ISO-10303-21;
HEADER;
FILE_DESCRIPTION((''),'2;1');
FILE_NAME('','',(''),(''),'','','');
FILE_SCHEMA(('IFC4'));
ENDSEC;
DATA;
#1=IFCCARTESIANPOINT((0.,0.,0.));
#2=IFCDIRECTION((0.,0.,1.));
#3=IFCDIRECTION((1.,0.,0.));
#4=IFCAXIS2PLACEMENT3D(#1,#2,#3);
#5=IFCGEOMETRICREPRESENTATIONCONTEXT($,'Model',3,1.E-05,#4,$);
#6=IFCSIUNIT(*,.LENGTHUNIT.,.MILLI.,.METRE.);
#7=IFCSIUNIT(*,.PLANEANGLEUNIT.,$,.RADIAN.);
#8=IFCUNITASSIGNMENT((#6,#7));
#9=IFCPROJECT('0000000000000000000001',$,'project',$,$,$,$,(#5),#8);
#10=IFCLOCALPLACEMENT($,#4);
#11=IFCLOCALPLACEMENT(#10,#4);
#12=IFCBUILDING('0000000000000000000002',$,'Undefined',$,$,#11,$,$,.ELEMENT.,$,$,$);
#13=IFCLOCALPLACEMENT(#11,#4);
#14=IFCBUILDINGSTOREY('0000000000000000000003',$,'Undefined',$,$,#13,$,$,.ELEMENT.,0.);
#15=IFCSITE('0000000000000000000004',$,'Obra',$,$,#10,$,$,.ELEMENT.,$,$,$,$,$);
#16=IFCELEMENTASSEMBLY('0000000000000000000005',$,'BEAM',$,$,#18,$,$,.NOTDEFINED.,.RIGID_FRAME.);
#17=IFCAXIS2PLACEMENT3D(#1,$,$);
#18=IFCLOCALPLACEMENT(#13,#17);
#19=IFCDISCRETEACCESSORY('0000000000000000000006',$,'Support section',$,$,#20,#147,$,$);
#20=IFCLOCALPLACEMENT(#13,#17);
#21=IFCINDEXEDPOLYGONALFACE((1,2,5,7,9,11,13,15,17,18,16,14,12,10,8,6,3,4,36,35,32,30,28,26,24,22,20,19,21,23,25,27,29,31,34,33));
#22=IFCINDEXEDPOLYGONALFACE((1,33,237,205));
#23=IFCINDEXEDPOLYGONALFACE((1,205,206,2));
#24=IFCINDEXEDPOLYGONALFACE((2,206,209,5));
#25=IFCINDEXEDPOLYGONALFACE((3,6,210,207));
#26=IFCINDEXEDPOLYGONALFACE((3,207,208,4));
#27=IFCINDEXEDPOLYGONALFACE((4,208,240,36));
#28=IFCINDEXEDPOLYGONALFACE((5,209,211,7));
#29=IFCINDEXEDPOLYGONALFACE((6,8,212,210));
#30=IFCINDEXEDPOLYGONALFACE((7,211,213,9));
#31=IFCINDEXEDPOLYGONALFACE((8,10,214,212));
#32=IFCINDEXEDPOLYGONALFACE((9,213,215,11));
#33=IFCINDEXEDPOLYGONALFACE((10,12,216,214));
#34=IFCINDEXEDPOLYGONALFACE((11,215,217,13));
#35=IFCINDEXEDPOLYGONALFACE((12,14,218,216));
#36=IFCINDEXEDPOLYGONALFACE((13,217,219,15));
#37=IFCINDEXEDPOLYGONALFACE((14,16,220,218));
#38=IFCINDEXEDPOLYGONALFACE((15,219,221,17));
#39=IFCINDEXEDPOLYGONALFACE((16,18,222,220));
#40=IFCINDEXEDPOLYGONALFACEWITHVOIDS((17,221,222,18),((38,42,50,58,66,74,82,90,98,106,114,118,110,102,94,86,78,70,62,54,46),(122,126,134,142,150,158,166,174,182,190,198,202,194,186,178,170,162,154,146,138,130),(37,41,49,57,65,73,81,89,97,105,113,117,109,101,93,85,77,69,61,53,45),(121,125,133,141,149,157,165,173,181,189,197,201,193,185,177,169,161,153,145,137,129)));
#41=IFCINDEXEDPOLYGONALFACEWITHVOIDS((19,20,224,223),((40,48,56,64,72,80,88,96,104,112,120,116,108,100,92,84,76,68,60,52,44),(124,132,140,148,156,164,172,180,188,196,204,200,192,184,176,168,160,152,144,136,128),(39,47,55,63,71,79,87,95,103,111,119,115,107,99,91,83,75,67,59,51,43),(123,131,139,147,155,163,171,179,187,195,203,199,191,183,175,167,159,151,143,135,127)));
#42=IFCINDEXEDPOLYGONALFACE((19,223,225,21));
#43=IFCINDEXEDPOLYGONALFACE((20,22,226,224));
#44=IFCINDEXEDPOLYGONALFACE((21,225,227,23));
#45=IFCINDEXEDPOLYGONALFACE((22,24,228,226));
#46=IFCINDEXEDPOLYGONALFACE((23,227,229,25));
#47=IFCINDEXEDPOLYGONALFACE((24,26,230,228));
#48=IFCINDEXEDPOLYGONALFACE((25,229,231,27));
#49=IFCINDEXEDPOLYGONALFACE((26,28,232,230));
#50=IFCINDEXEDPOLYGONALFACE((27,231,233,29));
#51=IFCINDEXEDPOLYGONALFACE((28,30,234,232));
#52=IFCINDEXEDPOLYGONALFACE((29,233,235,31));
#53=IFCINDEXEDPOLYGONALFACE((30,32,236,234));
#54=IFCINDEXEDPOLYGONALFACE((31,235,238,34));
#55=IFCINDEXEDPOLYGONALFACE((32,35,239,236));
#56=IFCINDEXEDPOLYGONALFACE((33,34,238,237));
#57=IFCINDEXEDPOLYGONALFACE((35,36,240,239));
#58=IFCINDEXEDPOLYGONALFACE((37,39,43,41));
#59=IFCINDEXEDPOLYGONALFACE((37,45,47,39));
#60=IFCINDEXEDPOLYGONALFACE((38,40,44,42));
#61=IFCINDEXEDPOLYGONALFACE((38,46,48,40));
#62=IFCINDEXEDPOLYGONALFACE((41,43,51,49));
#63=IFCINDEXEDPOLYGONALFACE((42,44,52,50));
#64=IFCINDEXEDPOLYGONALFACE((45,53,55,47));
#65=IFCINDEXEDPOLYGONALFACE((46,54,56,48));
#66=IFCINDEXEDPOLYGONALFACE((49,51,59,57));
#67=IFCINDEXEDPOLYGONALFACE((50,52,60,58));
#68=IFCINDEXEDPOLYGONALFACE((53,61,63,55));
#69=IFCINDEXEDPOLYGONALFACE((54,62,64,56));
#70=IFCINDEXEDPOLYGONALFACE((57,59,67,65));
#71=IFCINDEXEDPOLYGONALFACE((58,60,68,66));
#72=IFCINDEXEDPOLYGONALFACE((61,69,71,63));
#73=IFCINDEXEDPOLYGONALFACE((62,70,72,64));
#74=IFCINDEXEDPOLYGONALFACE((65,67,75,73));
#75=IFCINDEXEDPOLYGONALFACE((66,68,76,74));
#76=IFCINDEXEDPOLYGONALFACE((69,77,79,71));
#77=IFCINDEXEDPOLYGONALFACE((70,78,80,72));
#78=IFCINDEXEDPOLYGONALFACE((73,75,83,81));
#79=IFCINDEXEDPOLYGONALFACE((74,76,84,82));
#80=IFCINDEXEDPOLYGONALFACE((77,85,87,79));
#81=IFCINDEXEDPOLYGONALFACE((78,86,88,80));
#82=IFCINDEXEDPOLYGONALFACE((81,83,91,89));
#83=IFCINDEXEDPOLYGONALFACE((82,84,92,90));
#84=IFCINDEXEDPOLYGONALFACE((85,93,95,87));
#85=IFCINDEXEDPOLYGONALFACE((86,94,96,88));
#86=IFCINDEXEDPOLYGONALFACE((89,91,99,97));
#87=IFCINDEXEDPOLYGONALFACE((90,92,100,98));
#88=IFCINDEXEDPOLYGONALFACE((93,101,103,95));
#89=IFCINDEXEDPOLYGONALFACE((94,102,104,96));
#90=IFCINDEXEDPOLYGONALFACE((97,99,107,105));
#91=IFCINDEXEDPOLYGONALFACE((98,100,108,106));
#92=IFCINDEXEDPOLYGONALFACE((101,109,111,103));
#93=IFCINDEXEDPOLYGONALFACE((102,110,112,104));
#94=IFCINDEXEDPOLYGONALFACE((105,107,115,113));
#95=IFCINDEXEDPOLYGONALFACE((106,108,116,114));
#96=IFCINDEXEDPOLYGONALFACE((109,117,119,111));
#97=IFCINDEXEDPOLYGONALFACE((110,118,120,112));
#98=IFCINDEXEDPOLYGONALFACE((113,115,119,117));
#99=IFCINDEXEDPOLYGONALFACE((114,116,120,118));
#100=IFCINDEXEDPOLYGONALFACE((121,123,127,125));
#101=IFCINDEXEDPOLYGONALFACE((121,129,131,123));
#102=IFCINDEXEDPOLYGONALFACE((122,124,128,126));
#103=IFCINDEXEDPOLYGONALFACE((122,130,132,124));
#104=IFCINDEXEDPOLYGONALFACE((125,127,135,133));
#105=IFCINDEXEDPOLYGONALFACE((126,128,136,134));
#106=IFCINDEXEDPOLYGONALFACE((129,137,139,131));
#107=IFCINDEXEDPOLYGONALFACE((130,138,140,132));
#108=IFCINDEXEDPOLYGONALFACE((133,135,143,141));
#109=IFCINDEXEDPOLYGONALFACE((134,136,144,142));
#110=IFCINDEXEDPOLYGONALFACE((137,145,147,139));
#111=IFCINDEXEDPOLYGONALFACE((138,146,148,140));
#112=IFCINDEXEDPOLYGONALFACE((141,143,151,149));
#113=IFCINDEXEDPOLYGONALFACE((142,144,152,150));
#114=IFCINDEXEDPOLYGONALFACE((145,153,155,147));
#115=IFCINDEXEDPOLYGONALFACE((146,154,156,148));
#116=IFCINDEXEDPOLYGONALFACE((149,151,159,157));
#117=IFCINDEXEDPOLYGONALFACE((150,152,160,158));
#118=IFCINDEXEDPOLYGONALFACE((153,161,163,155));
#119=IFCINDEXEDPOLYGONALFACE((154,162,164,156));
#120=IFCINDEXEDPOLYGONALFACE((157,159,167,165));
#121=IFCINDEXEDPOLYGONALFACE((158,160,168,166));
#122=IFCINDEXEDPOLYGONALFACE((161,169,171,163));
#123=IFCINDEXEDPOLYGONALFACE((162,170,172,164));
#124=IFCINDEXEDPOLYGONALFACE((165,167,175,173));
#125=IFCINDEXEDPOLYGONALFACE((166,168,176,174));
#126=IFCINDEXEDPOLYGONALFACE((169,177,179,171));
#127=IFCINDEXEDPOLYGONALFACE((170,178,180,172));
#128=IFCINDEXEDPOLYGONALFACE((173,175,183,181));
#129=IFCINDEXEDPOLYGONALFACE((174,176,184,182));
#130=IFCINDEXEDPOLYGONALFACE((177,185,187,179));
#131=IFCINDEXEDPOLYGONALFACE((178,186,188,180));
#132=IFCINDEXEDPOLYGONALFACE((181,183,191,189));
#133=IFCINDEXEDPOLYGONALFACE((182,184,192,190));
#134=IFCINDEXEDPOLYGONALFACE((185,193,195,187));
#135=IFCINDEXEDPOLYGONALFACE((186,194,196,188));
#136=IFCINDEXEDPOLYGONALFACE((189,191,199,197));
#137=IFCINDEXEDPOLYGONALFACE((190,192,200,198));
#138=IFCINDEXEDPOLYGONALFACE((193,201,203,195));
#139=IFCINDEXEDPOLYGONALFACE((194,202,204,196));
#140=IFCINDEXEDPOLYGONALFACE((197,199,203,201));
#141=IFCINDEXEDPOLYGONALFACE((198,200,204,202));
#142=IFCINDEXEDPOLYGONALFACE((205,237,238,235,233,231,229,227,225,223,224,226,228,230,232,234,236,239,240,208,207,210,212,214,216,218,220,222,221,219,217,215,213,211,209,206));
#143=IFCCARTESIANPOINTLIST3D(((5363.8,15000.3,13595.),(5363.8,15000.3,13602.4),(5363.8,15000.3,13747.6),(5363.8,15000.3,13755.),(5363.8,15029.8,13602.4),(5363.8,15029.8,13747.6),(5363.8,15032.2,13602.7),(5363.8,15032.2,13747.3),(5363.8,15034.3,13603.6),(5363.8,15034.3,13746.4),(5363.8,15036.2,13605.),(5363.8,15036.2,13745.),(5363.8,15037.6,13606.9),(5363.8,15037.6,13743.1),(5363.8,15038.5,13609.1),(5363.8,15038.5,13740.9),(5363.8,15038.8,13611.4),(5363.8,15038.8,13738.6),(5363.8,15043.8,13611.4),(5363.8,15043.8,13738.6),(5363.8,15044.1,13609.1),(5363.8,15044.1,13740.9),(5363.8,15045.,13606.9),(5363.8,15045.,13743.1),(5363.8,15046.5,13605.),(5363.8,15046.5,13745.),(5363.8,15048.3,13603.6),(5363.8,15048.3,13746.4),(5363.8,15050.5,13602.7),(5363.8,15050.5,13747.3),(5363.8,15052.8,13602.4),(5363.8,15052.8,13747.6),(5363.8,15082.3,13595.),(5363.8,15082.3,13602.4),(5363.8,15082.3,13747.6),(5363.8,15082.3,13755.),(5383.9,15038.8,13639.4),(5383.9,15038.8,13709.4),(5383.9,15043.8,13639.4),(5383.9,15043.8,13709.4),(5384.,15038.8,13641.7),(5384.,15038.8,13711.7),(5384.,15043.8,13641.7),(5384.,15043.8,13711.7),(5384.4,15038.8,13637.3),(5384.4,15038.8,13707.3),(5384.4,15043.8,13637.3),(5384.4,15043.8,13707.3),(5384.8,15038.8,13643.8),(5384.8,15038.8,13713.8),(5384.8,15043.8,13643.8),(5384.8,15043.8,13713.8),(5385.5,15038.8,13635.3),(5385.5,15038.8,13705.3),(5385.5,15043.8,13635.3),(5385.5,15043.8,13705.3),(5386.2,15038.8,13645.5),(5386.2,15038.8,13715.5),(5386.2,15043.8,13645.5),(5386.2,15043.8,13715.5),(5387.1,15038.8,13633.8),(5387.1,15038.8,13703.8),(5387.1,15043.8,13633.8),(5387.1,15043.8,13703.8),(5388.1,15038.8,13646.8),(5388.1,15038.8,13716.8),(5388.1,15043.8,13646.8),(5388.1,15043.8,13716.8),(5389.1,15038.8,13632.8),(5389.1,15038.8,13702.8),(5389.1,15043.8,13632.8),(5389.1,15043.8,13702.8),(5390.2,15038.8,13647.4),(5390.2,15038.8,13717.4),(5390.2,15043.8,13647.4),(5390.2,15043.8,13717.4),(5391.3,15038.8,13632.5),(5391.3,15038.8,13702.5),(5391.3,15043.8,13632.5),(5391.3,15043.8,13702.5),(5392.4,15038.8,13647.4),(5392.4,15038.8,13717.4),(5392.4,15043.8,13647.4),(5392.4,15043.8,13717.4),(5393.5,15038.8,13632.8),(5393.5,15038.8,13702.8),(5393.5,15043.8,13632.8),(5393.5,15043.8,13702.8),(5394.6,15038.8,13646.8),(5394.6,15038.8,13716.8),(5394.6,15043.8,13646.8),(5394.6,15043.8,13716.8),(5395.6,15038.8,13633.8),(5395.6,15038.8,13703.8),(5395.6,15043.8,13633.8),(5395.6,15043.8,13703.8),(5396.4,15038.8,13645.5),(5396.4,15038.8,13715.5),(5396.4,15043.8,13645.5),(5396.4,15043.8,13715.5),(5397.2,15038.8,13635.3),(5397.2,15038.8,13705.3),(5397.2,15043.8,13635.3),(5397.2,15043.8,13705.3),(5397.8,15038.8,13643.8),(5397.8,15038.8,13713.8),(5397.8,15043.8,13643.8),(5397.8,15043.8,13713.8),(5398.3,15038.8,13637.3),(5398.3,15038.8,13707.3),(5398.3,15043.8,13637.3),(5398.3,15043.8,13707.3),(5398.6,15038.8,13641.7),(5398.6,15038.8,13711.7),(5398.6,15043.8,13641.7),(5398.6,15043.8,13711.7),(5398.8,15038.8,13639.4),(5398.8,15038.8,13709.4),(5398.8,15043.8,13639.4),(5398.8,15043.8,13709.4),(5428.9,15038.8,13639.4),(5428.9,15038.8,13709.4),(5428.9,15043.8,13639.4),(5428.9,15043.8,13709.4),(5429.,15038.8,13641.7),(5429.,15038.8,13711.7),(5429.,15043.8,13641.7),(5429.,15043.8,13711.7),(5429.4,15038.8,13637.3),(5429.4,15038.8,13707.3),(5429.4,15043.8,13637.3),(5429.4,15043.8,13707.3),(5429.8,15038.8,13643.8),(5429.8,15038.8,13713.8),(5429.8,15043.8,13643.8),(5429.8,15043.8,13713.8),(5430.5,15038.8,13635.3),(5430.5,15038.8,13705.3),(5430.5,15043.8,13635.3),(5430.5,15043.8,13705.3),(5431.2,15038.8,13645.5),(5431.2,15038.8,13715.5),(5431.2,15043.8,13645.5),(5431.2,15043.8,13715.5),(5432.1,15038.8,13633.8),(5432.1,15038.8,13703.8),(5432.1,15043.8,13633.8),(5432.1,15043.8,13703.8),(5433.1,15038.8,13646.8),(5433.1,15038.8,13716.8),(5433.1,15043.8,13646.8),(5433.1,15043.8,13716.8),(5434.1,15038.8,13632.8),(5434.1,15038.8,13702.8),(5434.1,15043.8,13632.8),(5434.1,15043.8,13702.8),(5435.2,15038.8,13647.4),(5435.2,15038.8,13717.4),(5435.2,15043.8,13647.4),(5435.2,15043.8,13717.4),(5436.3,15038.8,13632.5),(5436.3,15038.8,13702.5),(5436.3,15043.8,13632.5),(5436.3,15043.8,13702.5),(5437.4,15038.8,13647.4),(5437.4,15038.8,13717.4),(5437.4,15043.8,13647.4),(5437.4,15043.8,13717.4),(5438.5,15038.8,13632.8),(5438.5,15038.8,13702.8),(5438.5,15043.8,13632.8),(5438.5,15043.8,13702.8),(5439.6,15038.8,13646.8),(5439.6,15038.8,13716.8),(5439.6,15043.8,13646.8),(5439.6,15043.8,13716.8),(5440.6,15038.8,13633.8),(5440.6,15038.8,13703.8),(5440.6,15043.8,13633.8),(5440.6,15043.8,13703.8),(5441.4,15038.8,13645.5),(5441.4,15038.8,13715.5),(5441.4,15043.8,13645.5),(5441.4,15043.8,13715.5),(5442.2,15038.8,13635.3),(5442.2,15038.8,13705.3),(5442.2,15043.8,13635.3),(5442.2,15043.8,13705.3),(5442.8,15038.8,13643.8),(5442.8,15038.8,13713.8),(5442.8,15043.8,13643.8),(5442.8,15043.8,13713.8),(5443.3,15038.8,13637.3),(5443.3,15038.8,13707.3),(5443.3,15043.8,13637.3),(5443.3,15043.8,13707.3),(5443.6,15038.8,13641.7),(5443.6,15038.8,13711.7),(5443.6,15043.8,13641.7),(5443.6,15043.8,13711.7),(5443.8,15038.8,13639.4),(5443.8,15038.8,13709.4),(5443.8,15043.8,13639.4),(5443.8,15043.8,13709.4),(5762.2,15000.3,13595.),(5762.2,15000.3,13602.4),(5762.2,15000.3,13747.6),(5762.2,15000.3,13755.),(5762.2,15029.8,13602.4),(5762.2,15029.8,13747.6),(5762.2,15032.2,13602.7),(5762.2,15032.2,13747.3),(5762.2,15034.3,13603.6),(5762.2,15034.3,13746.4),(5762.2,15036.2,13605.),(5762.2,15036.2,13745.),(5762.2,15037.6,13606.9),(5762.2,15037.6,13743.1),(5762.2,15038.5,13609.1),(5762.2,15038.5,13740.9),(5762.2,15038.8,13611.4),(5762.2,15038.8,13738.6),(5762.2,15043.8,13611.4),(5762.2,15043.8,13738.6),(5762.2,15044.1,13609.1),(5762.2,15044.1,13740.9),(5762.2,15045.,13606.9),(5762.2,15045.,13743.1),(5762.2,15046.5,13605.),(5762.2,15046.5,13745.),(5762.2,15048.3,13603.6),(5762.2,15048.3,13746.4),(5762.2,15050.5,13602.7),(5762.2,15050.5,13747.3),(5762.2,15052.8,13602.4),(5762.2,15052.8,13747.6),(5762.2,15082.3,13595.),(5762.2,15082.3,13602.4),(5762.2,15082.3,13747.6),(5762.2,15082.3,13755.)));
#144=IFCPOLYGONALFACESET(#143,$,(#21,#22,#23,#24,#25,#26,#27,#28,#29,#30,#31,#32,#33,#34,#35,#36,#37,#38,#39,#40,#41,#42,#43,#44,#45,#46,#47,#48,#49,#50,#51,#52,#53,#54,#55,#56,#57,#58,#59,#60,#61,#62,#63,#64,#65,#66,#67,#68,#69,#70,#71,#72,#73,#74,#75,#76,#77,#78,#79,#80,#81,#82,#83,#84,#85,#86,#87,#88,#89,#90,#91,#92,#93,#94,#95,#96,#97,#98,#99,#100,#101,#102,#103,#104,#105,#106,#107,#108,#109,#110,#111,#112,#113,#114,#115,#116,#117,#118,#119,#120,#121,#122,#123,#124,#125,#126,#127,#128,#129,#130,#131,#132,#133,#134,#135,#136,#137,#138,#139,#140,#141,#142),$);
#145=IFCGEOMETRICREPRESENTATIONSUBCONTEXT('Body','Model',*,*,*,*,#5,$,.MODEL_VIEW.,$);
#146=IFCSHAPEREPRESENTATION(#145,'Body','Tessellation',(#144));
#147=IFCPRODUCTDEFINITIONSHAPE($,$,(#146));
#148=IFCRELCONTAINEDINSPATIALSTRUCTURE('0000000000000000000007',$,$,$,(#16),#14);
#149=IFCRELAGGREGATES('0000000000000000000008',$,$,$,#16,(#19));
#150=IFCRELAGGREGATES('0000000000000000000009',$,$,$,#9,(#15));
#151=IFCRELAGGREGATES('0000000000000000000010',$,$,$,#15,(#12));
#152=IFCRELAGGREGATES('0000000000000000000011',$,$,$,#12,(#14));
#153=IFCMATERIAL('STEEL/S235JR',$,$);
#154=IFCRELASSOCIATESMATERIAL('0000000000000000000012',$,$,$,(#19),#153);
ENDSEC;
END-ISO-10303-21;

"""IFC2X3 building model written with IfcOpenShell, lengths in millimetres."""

from ifc_helpers import new_model, si_unit, frame, origin_with_axes, origin_2d_with_axis, place, context, subcontext, project, spatial, circle, i_section, extrude, clip, halfspace, source, transform, mapped, material, element, aggregate, save


model = new_model("IFC2X3")

# Units and contexts
model_context = context("Model", 3, precision=1e-05, world=origin_with_axes())
body_context = subcontext(model_context, "Body", "Model", "MODEL_VIEW")
ifc_project = project(units=[si_unit("LENGTHUNIT", "METRE", prefix="MILLI"), si_unit("PLANEANGLEUNIT", "RADIAN")], contexts=[model_context])

# Site, building, storey
site_placement = place(None, origin_with_axes())
site = spatial("IfcSite", under=ifc_project, at=site_placement, Name="Obra", CompositionType="ELEMENT")
building_placement = place(site_placement, origin_with_axes())
building = spatial("IfcBuilding", under=site, at=building_placement, Name="Undefined", CompositionType="ELEMENT")
storey_placement = place(building_placement, origin_with_axes())
storey = spatial("IfcBuildingStorey", under=building, at=storey_placement, Name="Undefined", CompositionType="ELEMENT", Elevation=0.0)

# Element assembly
assembly_1_placement = place(storey_placement, origin_with_axes())
assembly_1 = element("IfcElementAssembly", 1, at=assembly_1_placement, inside=storey, Name="BEAM", AssemblyPlace="NOTDEFINED", PredefinedType="RIGID_FRAME")
ifc_material_1 = material(Name="STEEL/S235JR")

# Discrete accessory, opening
discrete_accessory_1_placement = place(assembly_1_placement, frame((5373.8, 15041.3, 13675.0), z_axis=(0.0, 0.0, 1.0), x_axis=(1.0, 0.0, 0.0)))
discrete_accessory_1 = element("IfcDiscreteAccessory", 2, at=discrete_accessory_1_placement, material=ifc_material_1, Name="Support section", context=body_context, shape_type="Clipping", body=[
    clip(clip(extrude(i_section(OverallWidth=82.0, OverallDepth=160.0, WebThickness=5.0, FlangeThickness=7.4, FilletRadius=9.0, at=origin_2d_with_axis()), frame((388.3, 0.0, 0.0), z_axis=(-1.0, 0.0, 0.0), x_axis=(0.0, -1.0, 0.0)), (0.0, 0.0, 1.0), 398.3), halfspace(frame((388.3, 0.0, 580.0), z_axis=(1.0, 0.0, 0.0), x_axis=(0.0, 1.0, 0.0)), False)), halfspace(frame((-10.0, 0.0, -180.0), z_axis=(1.0, 0.0, 0.0), x_axis=(0.0, -1.0, 0.0)), True)),
])
shared_shape_1 = source(origin_with_axes(), body_context, "Body", "SweptSolid", [
    extrude(circle(Radius=7.5, at=origin_2d_with_axis()), frame((0.0, -2.6, 0.0), z_axis=(0.0, 1.0, 0.0), x_axis=(1.0, 0.0, 0.0)), (0.0, 0.0, 1.0), 5.2),
])
opening_1_placement = place(assembly_1_placement, frame((5413.8, 15041.3, 13710.0), z_axis=(1.0, 0.0, 0.0), x_axis=(0.0, 0.0, -1.0)))
element("IfcOpeningElement", 3, at=opening_1_placement, cuts=discrete_accessory_1, ObjectType="Opening", context=body_context, shape_type="MappedRepresentation", body=[
    mapped(shared_shape_1, transform((0.0, 0.0, -22.5))),
    mapped(shared_shape_1, transform((70.0, 0.0, -22.5))),
    mapped(shared_shape_1, transform((0.0, 0.0, 22.5))),
    mapped(shared_shape_1, transform((70.0, 0.0, 22.5))),
])
aggregate(assembly_1, [discrete_accessory_1])

save(model, "model.ifc")
